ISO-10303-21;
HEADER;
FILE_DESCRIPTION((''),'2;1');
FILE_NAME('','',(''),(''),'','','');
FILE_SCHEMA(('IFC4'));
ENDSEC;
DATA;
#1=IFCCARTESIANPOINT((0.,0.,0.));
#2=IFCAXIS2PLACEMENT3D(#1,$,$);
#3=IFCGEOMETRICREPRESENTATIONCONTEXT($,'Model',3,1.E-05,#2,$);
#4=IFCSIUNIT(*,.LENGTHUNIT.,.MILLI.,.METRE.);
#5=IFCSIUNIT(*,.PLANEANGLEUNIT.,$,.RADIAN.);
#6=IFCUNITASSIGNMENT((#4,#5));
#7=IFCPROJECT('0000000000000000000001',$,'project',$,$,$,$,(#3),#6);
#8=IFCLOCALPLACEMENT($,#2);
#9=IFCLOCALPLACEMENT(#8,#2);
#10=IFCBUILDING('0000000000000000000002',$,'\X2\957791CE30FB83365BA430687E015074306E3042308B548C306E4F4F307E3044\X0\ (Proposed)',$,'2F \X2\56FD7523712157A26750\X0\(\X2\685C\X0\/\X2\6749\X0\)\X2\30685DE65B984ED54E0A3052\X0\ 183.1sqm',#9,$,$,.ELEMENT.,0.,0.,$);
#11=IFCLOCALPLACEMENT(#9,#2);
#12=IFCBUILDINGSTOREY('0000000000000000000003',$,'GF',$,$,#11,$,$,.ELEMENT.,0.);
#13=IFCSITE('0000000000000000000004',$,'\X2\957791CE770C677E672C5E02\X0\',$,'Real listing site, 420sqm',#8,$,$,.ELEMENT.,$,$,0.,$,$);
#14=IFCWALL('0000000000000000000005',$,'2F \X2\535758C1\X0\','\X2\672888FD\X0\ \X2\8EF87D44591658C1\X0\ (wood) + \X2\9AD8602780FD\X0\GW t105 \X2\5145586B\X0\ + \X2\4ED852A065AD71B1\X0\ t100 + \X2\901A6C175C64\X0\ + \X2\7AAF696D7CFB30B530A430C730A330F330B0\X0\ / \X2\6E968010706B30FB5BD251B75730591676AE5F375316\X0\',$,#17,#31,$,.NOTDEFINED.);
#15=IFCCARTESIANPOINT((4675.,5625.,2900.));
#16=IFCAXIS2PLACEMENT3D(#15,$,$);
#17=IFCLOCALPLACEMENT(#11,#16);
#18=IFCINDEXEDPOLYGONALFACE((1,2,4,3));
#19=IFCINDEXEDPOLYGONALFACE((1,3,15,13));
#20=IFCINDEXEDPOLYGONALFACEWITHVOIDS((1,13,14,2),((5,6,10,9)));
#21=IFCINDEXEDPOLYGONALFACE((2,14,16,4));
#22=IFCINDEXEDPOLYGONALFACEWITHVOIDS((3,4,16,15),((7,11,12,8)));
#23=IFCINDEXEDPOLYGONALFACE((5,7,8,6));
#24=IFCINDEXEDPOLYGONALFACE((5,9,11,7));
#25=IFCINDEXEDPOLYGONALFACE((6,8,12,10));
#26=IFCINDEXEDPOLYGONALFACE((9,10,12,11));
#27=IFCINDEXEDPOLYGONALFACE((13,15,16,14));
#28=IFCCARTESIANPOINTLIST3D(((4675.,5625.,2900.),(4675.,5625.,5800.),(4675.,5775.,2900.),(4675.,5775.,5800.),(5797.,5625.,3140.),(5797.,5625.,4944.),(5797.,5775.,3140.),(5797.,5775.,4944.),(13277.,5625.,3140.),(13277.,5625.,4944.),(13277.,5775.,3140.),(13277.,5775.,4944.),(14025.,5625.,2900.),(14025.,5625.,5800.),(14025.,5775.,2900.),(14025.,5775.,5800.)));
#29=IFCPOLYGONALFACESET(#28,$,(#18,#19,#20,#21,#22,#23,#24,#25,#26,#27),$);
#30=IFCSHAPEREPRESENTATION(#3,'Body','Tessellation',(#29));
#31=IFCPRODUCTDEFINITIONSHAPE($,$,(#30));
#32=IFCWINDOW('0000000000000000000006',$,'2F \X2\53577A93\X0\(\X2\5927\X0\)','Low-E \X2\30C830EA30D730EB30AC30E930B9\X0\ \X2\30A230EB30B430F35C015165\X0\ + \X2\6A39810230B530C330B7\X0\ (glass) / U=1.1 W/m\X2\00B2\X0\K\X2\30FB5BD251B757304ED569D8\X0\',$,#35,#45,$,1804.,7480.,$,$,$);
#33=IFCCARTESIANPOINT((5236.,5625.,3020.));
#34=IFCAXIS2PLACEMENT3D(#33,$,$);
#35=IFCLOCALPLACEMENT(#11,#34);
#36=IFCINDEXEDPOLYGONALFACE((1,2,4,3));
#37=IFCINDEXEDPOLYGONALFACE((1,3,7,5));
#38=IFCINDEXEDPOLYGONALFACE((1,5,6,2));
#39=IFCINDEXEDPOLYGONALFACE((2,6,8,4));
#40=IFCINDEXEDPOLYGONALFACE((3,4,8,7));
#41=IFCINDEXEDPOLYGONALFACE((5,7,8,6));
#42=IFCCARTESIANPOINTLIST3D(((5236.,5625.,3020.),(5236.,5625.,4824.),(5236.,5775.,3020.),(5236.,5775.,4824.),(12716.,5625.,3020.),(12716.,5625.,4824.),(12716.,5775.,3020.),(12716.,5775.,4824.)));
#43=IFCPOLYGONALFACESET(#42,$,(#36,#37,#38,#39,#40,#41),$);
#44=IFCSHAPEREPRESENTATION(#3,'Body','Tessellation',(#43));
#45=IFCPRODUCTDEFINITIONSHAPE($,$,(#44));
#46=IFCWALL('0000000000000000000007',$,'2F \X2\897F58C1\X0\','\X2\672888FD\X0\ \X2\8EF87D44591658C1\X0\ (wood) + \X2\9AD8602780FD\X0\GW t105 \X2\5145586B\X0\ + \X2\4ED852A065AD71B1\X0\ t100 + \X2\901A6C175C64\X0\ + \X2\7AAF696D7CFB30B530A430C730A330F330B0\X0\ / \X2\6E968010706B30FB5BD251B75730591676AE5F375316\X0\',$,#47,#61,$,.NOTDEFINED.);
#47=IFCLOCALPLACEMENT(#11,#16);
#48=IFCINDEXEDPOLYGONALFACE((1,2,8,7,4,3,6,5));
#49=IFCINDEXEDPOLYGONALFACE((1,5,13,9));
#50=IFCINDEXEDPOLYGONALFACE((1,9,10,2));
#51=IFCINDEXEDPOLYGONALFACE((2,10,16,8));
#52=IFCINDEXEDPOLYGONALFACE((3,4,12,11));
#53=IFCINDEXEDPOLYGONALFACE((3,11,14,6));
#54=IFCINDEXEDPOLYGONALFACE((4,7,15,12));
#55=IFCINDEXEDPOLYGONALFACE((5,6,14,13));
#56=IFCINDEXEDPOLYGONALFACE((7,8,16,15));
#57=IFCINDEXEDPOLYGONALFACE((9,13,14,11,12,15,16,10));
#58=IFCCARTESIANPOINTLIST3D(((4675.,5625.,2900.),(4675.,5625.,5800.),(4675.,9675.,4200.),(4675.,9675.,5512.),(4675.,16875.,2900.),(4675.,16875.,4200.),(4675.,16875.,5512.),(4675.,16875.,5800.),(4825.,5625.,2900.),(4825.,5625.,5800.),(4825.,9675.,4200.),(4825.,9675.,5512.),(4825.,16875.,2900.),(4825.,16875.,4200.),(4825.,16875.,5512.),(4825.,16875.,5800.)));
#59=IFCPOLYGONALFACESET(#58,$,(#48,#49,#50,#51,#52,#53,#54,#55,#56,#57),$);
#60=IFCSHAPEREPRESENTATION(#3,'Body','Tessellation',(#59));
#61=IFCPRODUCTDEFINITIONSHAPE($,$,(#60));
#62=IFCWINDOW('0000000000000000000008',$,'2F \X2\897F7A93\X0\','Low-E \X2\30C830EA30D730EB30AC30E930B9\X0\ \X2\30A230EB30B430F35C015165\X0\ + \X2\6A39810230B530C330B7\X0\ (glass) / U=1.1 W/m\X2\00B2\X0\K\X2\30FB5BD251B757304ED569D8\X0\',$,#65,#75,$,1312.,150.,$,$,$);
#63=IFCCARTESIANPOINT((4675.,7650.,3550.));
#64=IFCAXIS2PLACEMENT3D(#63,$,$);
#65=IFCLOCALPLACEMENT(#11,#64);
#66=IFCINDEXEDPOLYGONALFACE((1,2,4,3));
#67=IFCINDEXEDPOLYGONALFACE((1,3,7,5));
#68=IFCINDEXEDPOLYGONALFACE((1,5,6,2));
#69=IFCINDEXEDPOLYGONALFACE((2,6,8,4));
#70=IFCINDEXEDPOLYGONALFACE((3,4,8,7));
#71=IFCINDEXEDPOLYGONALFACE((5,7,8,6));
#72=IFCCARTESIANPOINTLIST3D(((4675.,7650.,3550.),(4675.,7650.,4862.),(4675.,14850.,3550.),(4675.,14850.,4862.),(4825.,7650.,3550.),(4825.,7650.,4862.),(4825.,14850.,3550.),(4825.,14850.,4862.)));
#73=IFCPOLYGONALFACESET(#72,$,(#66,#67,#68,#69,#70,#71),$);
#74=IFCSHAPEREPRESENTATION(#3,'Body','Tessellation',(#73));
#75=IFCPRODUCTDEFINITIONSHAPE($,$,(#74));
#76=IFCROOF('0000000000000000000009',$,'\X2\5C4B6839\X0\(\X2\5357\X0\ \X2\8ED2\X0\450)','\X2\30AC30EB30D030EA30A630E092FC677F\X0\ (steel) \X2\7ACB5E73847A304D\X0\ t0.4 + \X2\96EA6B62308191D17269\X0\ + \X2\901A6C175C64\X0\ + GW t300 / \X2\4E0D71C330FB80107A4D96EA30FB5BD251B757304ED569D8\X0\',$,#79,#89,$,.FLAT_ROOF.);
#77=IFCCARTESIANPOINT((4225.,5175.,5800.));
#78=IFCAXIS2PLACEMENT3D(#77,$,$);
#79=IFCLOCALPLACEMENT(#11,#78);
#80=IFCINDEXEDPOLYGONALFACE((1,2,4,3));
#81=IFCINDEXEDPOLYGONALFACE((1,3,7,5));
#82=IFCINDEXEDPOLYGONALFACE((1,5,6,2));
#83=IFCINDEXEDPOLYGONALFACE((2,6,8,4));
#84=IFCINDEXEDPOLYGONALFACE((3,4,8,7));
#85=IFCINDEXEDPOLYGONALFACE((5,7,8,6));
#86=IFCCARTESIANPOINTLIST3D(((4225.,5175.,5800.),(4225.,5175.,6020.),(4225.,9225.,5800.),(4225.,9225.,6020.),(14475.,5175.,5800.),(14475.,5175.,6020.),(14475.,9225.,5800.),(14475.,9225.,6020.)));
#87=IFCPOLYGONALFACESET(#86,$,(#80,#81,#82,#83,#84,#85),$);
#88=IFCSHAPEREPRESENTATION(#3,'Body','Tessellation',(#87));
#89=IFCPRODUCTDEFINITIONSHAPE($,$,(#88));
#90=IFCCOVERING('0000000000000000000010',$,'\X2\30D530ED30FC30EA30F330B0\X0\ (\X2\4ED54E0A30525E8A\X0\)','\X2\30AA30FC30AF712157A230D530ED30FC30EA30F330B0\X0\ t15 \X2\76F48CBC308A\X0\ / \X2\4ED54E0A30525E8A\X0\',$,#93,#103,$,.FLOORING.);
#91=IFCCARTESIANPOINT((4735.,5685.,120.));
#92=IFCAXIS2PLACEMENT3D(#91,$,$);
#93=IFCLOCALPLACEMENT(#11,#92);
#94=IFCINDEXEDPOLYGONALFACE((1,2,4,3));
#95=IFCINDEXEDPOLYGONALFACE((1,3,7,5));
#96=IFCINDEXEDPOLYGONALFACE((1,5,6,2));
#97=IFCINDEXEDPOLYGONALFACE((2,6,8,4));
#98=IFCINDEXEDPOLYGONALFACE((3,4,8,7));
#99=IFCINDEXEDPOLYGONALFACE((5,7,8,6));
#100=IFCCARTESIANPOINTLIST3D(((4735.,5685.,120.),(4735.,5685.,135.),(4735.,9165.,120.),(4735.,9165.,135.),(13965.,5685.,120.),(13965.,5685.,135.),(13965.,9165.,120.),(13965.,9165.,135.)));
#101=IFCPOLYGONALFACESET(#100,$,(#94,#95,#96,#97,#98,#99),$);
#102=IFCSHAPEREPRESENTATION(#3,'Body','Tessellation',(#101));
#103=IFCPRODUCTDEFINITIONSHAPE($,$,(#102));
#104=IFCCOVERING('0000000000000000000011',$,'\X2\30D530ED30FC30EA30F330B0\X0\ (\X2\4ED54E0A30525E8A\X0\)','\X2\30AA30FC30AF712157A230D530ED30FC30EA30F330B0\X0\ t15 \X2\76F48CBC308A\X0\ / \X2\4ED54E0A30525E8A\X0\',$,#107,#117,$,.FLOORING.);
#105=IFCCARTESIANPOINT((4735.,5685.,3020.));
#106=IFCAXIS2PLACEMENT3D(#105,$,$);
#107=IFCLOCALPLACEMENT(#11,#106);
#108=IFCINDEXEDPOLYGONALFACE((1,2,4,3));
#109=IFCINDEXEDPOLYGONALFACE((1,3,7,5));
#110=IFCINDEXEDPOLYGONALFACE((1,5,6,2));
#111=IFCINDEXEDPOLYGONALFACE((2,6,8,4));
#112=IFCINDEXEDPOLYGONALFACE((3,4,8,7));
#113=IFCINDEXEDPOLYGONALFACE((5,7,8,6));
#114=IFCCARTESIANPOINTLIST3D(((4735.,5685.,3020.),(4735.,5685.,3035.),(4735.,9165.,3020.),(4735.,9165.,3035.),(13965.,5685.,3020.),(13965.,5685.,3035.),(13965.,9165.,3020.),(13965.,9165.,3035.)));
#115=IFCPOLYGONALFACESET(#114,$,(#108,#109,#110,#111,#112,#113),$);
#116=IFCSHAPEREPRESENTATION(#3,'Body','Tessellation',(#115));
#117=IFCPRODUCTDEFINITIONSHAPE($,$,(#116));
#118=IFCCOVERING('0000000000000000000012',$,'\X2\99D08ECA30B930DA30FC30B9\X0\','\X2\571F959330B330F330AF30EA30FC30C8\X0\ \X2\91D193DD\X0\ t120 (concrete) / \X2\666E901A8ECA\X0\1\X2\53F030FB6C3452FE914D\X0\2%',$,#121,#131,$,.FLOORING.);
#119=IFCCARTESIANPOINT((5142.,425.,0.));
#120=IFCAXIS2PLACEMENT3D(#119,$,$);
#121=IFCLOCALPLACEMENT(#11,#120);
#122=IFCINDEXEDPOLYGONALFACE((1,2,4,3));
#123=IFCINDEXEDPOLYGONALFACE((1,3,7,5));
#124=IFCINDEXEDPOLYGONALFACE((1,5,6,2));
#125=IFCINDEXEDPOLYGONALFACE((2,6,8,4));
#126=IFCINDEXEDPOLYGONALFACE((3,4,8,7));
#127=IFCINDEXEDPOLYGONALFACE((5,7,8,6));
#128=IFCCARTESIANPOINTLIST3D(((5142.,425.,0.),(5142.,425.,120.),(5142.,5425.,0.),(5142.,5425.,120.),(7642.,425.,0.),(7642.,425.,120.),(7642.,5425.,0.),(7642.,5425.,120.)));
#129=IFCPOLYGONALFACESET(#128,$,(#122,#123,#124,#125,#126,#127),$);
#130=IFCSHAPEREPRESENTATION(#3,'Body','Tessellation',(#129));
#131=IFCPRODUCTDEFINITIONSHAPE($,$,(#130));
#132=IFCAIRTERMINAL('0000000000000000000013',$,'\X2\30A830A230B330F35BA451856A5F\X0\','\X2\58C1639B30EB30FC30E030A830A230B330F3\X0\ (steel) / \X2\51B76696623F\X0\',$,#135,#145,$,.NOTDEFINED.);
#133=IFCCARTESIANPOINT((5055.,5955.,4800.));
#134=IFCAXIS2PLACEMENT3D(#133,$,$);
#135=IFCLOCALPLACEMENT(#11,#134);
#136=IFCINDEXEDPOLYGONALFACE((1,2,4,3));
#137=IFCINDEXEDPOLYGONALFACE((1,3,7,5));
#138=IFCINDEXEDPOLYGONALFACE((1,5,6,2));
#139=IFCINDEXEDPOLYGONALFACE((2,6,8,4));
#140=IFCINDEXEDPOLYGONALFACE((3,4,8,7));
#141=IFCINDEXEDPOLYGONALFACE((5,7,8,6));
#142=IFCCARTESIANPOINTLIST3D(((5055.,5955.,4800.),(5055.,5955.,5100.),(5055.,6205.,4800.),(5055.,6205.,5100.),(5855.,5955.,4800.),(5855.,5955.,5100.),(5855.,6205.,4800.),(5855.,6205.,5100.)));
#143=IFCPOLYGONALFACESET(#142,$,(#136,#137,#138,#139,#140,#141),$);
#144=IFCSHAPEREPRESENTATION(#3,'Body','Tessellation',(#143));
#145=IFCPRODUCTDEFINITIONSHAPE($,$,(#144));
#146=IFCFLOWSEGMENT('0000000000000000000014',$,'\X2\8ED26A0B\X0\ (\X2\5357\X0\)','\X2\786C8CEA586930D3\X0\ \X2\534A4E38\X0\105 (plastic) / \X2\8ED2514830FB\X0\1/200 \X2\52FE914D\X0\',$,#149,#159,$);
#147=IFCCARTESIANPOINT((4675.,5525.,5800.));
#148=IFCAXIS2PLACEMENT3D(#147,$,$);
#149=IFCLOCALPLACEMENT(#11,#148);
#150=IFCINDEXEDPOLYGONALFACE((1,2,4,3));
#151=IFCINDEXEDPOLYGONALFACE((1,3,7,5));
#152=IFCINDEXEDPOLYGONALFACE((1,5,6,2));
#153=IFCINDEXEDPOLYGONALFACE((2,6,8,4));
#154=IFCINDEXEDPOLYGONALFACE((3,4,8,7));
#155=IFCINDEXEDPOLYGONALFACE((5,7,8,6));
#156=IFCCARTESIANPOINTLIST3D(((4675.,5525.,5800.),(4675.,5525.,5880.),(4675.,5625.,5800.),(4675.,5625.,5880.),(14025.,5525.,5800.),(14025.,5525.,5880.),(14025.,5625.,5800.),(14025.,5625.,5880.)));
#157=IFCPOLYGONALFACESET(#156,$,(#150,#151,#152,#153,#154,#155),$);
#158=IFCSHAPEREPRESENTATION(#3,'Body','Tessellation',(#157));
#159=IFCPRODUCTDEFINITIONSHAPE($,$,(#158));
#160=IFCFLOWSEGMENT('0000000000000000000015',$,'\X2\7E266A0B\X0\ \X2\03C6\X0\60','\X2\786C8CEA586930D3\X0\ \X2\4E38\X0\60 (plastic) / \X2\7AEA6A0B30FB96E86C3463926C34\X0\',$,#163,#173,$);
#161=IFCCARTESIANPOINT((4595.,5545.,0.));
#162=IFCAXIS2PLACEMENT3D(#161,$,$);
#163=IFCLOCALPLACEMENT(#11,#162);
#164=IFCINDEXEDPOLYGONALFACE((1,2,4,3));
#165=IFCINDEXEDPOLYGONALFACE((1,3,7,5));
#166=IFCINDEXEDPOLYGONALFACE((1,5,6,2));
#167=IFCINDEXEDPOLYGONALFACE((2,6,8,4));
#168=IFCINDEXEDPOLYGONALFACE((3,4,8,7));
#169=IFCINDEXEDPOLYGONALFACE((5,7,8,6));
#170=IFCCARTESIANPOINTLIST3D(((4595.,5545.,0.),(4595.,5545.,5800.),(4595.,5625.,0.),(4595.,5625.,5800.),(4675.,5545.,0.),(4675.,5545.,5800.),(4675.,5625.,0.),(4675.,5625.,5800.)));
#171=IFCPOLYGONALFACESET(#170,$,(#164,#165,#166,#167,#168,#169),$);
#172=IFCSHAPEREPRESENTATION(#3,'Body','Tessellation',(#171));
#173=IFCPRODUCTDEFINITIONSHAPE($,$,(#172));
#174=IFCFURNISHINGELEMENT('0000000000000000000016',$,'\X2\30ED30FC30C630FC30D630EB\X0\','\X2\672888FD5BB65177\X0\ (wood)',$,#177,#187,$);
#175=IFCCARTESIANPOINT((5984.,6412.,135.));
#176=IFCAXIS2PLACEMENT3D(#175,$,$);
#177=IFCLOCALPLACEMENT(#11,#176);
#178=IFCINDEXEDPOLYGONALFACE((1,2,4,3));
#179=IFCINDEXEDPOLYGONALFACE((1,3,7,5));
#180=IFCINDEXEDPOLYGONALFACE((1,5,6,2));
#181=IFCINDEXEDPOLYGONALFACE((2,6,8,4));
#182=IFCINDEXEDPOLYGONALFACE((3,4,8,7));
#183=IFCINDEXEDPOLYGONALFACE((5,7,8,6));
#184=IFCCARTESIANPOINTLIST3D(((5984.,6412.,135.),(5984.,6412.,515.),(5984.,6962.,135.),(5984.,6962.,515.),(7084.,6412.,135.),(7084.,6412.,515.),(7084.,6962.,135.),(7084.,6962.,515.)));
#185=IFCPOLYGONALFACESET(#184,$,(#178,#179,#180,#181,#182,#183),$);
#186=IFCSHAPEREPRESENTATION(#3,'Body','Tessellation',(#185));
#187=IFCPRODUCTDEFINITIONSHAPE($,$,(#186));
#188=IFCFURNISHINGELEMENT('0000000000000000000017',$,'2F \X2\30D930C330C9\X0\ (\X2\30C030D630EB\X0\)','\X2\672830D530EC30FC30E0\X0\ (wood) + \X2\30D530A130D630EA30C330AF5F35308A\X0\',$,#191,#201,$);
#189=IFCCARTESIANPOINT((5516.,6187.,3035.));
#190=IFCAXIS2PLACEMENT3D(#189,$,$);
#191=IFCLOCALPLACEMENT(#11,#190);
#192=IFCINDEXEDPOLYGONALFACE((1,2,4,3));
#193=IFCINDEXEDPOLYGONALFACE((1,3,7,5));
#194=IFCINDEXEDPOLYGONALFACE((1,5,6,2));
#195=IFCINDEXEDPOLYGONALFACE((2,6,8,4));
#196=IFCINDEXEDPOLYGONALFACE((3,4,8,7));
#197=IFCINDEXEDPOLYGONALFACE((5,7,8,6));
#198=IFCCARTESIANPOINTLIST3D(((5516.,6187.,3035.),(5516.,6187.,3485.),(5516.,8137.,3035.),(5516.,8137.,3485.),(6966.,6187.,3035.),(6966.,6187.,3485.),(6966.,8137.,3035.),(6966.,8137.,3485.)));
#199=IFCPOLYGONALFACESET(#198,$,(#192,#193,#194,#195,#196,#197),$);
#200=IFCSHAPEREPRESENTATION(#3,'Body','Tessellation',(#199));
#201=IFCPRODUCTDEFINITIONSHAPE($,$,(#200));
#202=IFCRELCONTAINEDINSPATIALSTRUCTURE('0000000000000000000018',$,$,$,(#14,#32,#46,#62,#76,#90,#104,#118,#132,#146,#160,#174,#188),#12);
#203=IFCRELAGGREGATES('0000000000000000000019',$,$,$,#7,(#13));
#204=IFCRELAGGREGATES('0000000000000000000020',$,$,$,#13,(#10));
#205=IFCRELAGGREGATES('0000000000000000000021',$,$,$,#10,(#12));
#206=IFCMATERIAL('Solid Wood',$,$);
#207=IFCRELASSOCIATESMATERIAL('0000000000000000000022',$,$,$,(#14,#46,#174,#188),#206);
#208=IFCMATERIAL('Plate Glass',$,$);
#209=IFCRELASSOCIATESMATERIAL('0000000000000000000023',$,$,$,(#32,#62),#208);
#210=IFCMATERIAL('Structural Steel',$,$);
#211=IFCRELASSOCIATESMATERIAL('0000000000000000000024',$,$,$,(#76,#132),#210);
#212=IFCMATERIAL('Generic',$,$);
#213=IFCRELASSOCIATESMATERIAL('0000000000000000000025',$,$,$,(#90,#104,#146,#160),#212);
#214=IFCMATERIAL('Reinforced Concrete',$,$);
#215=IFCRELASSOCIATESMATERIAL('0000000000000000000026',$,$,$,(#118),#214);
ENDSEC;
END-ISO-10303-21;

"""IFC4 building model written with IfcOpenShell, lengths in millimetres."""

from ifc_helpers import new_model, si_unit, frame, frame_2d, origin, place, context, project, spatial, rectangle, extrude, material, element, fill, save


model = new_model("IFC4")

# Units and contexts
model_context = context("Model", 3, precision=1e-05, world=origin())
ifc_project = project(units=[si_unit("LENGTHUNIT", "METRE", prefix="MILLI"), si_unit("PLANEANGLEUNIT", "RADIAN")], contexts=[model_context])

# Site, building, storey
site_placement = place(None, origin())
site = spatial("IfcSite", under=ifc_project, at=site_placement, Name="長野県松本市", ObjectType="Real listing site, 420sqm", CompositionType="ELEMENT", RefElevation=0.0)
building_placement = place(site_placement, origin())
building = spatial("IfcBuilding", under=site, at=building_placement, Name="長野・茶室と縁側のある和の住まい (Proposed)", ObjectType="2F 国産無垢材(桜/杉)と左官仕上げ 183.1sqm", CompositionType="ELEMENT", ElevationOfRefHeight=0.0, ElevationOfTerrain=0.0)
storey_placement = place(building_placement, origin())
storey = spatial("IfcBuildingStorey", under=building, at=storey_placement, Name="GF", CompositionType="ELEMENT", Elevation=0.0)

# Shared definitions
ifc_material_1 = material(Name="Solid Wood")

# Shared definitions
ifc_material_2 = material(Name="Reinforced Concrete")

# Shared definitions
ifc_material_3 = material(Name="Plate Glass")

# Walls, openings, windows
wall_1_placement = place(storey_placement, frame((4675.0, 5625.0, 2900.0)))
wall_1 = element("IfcWall", 1, at=wall_1_placement, inside=storey, material=ifc_material_1, Name="2F 南壁", Description="木製 軸組外壁 (wood) + 高性能GW t105 充填 + 付加断熱 t100 + 通気層 + 窯業系サイディング / 準耐火・寒冷地外皮強化", PredefinedType="NOTDEFINED", context=model_context, shape_type="SweptSolid", body=[
    extrude(rectangle(XDim=9350.0, YDim=150.0, at=frame_2d((4675.0, 75.0))), frame((4675.0, 5625.0, 2900.0)), (0.0, 0.0, 1.0), 2900.0),
])
opening_1_placement = place(storey_placement, frame((5236.0, 5625.0, 3020.0)))
opening_1 = element("IfcOpeningElement", 2, at=opening_1_placement, cuts=wall_1, PredefinedType="NOTDEFINED", context=model_context, shape_type="SweptSolid", body=[
    extrude(rectangle(XDim=7480.0, YDim=150.0, at=frame_2d((3740.0, 75.0))), frame((5236.0, 5625.0, 3020.0)), (0.0, 0.0, 1.0), 1804.0),
])
window_1_placement = place(storey_placement, frame((5236.0, 5625.0, 3020.0)))
window_1 = element("IfcWindow", 3, at=window_1_placement, inside=storey, material=ifc_material_3, Name="2F 南窓(大)", Description="Low-E トリプルガラス アルゴン封入 + 樹脂サッシ (glass) / U=1.1 W/m²K・寒冷地仕様", OverallHeight=1804.0, OverallWidth=7480.0, context=model_context, shape_type="SweptSolid", body=[
    extrude(rectangle(XDim=7480.0, YDim=150.0, at=frame_2d((3740.0, 75.0))), frame((5236.0, 5625.0, 3020.0)), (0.0, 0.0, 1.0), 1804.0),
])
fill(opening_1, window_1)
wall_2_placement = place(storey_placement, frame((4675.0, 5625.0, 2900.0)))
wall_2 = element("IfcWall", 4, at=wall_2_placement, inside=storey, material=ifc_material_1, Name="2F 西壁", Description="木製 軸組外壁 (wood) + 高性能GW t105 充填 + 付加断熱 t100 + 通気層 + 窯業系サイディング / 準耐火・寒冷地外皮強化", PredefinedType="NOTDEFINED", context=model_context, shape_type="SweptSolid", body=[
    extrude(rectangle(XDim=150.0, YDim=11250.0, at=frame_2d((75.0, 5625.0))), frame((4675.0, 5625.0, 2900.0)), (0.0, 0.0, 1.0), 2900.0),
])
opening_2_placement = place(storey_placement, frame((4675.0, 7650.0, 3550.0)))
opening_2 = element("IfcOpeningElement", 5, at=opening_2_placement, cuts=wall_2, PredefinedType="NOTDEFINED", context=model_context, shape_type="SweptSolid", body=[
    extrude(rectangle(XDim=150.0, YDim=7200.0, at=frame_2d((75.0, 3600.0))), frame((4675.0, 7650.0, 3550.0)), (0.0, 0.0, 1.0), 1312.0),
])
window_2_placement = place(storey_placement, frame((4675.0, 7650.0, 3550.0)))
window_2 = element("IfcWindow", 6, at=window_2_placement, inside=storey, material=ifc_material_3, Name="2F 西窓", Description="Low-E トリプルガラス アルゴン封入 + 樹脂サッシ (glass) / U=1.1 W/m²K・寒冷地仕様", OverallHeight=1312.0, OverallWidth=150.0, context=model_context, shape_type="SweptSolid", body=[
    extrude(rectangle(XDim=150.0, YDim=7200.0, at=frame_2d((75.0, 3600.0))), frame((4675.0, 7650.0, 3550.0)), (0.0, 0.0, 1.0), 1312.0),
])
fill(opening_2, window_2)

# Roof
ifc_material_4 = material(Name="Structural Steel")
for number, where, name in (
    (7, (4225.0, 5175.0, 5800.0), "屋根(南 軒450)"),
):
    element("IfcRoof", number, at=place(storey_placement, frame(where)), inside=storey, material=ifc_material_4, Name=name, Description="ガルバリウム鋼板 (steel) 立平葺き t0.4 + 雪止め金物 + 通気層 + GW t300 / 不燃・耐積雪・寒冷地仕様", PredefinedType="FLAT_ROOF", context=model_context, shape_type="SweptSolid", body=[
        extrude(rectangle(XDim=10250.0, YDim=4050.0, at=frame_2d((5125.0, 2025.0))), frame((4225.0, 5175.0, 5800.0)), (0.0, 0.0, 1.0), 220.0),
    ])

# Coverings
ifc_material_5 = material(Name="Generic")
covering_1_placement = place(storey_placement, frame((4735.0, 5685.0, 120.0)))
element("IfcCovering", 8, at=covering_1_placement, inside=storey, material=ifc_material_5, Name="フローリング (仕上げ床)", Description="オーク無垢フローリング t15 直貼り / 仕上げ床", PredefinedType="FLOORING", context=model_context, shape_type="SweptSolid", body=[
    extrude(rectangle(XDim=9230.0, YDim=3480.0, at=frame_2d((4615.0, 1740.0))), frame((4735.0, 5685.0, 120.0)), (0.0, 0.0, 1.0), 15.0),
])
covering_2_placement = place(storey_placement, frame((4735.0, 5685.0, 3020.0)))
element("IfcCovering", 9, at=covering_2_placement, inside=storey, material=ifc_material_5, Name="フローリング (仕上げ床)", Description="オーク無垢フローリング t15 直貼り / 仕上げ床", PredefinedType="FLOORING", context=model_context, shape_type="SweptSolid", body=[
    extrude(rectangle(XDim=9230.0, YDim=3480.0, at=frame_2d((4615.0, 1740.0))), frame((4735.0, 5685.0, 3020.0)), (0.0, 0.0, 1.0), 15.0),
])
covering_3_placement = place(storey_placement, frame((5142.0, 425.0, 0.0)))
element("IfcCovering", 10, at=covering_3_placement, inside=storey, material=ifc_material_2, Name="駐車スペース", Description="土間コンクリート 金鏝 t120 (concrete) / 普通車1台・水勾配2%", PredefinedType="FLOORING", context=model_context, shape_type="SweptSolid", body=[
    extrude(rectangle(XDim=2500.0, YDim=5000.0, at=frame_2d((1250.0, 2500.0))), frame((5142.0, 425.0, 0.0)), (0.0, 0.0, 1.0), 120.0),
])

# Air terminal
air_terminal_placement = place(storey_placement, frame((5055.0, 5955.0, 4800.0)))
element("IfcAirTerminal", 11, at=air_terminal_placement, inside=storey, material=ifc_material_4, Name="エアコン室内機", Description="壁掛ルームエアコン (steel) / 冷暖房", PredefinedType="NOTDEFINED", context=model_context, shape_type="SweptSolid", body=[
    extrude(rectangle(XDim=800.0, YDim=250.0, at=frame_2d((400.0, 125.0))), frame((5055.0, 5955.0, 4800.0)), (0.0, 0.0, 1.0), 300.0),
])

# Flow segments
flow_segment_1_placement = place(storey_placement, frame((4675.0, 5525.0, 5800.0)))
element("IfcFlowSegment", 12, at=flow_segment_1_placement, inside=storey, material=ifc_material_5, Name="軒樋 (南)", Description="硬質塩ビ 半丸105 (plastic) / 軒先・1/200 勾配", context=model_context, shape_type="SweptSolid", body=[
    extrude(rectangle(XDim=9350.0, YDim=100.0, at=frame_2d((4675.0, 50.0))), frame((4675.0, 5525.0, 5800.0)), (0.0, 0.0, 1.0), 80.0),
])
flow_segment_2_placement = place(storey_placement, frame((4595.0, 5545.0, 0.0)))
element("IfcFlowSegment", 13, at=flow_segment_2_placement, inside=storey, material=ifc_material_5, Name="縦樋 φ60", Description="硬質塩ビ 丸60 (plastic) / 竪樋・雨水排水", context=model_context, shape_type="SweptSolid", body=[
    extrude(rectangle(XDim=80.0, YDim=80.0, at=frame_2d((40.0, 40.0))), frame((4595.0, 5545.0, 0.0)), (0.0, 0.0, 1.0), 5800.0),
])

# Furnishing elements
furnishing_1_placement = place(storey_placement, frame((5984.0, 6412.0, 135.0)))
element("IfcFurnishingElement", 14, at=furnishing_1_placement, inside=storey, material=ifc_material_1, Name="ローテーブル", Description="木製家具 (wood)", context=model_context, shape_type="SweptSolid", body=[
    extrude(rectangle(XDim=1100.0, YDim=550.0, at=frame_2d((550.0, 275.0))), frame((5984.0, 6412.0, 135.0)), (0.0, 0.0, 1.0), 380.0),
])
furnishing_2_placement = place(storey_placement, frame((5516.0, 6187.0, 3035.0)))
element("IfcFurnishingElement", 15, at=furnishing_2_placement, inside=storey, material=ifc_material_1, Name="2F ベッド (ダブル)", Description="木フレーム (wood) + ファブリック張り", context=model_context, shape_type="SweptSolid", body=[
    extrude(rectangle(XDim=1450.0, YDim=1950.0, at=frame_2d((725.0, 975.0))), frame((5516.0, 6187.0, 3035.0)), (0.0, 0.0, 1.0), 450.0),
])

save(model, "model.ifc")
